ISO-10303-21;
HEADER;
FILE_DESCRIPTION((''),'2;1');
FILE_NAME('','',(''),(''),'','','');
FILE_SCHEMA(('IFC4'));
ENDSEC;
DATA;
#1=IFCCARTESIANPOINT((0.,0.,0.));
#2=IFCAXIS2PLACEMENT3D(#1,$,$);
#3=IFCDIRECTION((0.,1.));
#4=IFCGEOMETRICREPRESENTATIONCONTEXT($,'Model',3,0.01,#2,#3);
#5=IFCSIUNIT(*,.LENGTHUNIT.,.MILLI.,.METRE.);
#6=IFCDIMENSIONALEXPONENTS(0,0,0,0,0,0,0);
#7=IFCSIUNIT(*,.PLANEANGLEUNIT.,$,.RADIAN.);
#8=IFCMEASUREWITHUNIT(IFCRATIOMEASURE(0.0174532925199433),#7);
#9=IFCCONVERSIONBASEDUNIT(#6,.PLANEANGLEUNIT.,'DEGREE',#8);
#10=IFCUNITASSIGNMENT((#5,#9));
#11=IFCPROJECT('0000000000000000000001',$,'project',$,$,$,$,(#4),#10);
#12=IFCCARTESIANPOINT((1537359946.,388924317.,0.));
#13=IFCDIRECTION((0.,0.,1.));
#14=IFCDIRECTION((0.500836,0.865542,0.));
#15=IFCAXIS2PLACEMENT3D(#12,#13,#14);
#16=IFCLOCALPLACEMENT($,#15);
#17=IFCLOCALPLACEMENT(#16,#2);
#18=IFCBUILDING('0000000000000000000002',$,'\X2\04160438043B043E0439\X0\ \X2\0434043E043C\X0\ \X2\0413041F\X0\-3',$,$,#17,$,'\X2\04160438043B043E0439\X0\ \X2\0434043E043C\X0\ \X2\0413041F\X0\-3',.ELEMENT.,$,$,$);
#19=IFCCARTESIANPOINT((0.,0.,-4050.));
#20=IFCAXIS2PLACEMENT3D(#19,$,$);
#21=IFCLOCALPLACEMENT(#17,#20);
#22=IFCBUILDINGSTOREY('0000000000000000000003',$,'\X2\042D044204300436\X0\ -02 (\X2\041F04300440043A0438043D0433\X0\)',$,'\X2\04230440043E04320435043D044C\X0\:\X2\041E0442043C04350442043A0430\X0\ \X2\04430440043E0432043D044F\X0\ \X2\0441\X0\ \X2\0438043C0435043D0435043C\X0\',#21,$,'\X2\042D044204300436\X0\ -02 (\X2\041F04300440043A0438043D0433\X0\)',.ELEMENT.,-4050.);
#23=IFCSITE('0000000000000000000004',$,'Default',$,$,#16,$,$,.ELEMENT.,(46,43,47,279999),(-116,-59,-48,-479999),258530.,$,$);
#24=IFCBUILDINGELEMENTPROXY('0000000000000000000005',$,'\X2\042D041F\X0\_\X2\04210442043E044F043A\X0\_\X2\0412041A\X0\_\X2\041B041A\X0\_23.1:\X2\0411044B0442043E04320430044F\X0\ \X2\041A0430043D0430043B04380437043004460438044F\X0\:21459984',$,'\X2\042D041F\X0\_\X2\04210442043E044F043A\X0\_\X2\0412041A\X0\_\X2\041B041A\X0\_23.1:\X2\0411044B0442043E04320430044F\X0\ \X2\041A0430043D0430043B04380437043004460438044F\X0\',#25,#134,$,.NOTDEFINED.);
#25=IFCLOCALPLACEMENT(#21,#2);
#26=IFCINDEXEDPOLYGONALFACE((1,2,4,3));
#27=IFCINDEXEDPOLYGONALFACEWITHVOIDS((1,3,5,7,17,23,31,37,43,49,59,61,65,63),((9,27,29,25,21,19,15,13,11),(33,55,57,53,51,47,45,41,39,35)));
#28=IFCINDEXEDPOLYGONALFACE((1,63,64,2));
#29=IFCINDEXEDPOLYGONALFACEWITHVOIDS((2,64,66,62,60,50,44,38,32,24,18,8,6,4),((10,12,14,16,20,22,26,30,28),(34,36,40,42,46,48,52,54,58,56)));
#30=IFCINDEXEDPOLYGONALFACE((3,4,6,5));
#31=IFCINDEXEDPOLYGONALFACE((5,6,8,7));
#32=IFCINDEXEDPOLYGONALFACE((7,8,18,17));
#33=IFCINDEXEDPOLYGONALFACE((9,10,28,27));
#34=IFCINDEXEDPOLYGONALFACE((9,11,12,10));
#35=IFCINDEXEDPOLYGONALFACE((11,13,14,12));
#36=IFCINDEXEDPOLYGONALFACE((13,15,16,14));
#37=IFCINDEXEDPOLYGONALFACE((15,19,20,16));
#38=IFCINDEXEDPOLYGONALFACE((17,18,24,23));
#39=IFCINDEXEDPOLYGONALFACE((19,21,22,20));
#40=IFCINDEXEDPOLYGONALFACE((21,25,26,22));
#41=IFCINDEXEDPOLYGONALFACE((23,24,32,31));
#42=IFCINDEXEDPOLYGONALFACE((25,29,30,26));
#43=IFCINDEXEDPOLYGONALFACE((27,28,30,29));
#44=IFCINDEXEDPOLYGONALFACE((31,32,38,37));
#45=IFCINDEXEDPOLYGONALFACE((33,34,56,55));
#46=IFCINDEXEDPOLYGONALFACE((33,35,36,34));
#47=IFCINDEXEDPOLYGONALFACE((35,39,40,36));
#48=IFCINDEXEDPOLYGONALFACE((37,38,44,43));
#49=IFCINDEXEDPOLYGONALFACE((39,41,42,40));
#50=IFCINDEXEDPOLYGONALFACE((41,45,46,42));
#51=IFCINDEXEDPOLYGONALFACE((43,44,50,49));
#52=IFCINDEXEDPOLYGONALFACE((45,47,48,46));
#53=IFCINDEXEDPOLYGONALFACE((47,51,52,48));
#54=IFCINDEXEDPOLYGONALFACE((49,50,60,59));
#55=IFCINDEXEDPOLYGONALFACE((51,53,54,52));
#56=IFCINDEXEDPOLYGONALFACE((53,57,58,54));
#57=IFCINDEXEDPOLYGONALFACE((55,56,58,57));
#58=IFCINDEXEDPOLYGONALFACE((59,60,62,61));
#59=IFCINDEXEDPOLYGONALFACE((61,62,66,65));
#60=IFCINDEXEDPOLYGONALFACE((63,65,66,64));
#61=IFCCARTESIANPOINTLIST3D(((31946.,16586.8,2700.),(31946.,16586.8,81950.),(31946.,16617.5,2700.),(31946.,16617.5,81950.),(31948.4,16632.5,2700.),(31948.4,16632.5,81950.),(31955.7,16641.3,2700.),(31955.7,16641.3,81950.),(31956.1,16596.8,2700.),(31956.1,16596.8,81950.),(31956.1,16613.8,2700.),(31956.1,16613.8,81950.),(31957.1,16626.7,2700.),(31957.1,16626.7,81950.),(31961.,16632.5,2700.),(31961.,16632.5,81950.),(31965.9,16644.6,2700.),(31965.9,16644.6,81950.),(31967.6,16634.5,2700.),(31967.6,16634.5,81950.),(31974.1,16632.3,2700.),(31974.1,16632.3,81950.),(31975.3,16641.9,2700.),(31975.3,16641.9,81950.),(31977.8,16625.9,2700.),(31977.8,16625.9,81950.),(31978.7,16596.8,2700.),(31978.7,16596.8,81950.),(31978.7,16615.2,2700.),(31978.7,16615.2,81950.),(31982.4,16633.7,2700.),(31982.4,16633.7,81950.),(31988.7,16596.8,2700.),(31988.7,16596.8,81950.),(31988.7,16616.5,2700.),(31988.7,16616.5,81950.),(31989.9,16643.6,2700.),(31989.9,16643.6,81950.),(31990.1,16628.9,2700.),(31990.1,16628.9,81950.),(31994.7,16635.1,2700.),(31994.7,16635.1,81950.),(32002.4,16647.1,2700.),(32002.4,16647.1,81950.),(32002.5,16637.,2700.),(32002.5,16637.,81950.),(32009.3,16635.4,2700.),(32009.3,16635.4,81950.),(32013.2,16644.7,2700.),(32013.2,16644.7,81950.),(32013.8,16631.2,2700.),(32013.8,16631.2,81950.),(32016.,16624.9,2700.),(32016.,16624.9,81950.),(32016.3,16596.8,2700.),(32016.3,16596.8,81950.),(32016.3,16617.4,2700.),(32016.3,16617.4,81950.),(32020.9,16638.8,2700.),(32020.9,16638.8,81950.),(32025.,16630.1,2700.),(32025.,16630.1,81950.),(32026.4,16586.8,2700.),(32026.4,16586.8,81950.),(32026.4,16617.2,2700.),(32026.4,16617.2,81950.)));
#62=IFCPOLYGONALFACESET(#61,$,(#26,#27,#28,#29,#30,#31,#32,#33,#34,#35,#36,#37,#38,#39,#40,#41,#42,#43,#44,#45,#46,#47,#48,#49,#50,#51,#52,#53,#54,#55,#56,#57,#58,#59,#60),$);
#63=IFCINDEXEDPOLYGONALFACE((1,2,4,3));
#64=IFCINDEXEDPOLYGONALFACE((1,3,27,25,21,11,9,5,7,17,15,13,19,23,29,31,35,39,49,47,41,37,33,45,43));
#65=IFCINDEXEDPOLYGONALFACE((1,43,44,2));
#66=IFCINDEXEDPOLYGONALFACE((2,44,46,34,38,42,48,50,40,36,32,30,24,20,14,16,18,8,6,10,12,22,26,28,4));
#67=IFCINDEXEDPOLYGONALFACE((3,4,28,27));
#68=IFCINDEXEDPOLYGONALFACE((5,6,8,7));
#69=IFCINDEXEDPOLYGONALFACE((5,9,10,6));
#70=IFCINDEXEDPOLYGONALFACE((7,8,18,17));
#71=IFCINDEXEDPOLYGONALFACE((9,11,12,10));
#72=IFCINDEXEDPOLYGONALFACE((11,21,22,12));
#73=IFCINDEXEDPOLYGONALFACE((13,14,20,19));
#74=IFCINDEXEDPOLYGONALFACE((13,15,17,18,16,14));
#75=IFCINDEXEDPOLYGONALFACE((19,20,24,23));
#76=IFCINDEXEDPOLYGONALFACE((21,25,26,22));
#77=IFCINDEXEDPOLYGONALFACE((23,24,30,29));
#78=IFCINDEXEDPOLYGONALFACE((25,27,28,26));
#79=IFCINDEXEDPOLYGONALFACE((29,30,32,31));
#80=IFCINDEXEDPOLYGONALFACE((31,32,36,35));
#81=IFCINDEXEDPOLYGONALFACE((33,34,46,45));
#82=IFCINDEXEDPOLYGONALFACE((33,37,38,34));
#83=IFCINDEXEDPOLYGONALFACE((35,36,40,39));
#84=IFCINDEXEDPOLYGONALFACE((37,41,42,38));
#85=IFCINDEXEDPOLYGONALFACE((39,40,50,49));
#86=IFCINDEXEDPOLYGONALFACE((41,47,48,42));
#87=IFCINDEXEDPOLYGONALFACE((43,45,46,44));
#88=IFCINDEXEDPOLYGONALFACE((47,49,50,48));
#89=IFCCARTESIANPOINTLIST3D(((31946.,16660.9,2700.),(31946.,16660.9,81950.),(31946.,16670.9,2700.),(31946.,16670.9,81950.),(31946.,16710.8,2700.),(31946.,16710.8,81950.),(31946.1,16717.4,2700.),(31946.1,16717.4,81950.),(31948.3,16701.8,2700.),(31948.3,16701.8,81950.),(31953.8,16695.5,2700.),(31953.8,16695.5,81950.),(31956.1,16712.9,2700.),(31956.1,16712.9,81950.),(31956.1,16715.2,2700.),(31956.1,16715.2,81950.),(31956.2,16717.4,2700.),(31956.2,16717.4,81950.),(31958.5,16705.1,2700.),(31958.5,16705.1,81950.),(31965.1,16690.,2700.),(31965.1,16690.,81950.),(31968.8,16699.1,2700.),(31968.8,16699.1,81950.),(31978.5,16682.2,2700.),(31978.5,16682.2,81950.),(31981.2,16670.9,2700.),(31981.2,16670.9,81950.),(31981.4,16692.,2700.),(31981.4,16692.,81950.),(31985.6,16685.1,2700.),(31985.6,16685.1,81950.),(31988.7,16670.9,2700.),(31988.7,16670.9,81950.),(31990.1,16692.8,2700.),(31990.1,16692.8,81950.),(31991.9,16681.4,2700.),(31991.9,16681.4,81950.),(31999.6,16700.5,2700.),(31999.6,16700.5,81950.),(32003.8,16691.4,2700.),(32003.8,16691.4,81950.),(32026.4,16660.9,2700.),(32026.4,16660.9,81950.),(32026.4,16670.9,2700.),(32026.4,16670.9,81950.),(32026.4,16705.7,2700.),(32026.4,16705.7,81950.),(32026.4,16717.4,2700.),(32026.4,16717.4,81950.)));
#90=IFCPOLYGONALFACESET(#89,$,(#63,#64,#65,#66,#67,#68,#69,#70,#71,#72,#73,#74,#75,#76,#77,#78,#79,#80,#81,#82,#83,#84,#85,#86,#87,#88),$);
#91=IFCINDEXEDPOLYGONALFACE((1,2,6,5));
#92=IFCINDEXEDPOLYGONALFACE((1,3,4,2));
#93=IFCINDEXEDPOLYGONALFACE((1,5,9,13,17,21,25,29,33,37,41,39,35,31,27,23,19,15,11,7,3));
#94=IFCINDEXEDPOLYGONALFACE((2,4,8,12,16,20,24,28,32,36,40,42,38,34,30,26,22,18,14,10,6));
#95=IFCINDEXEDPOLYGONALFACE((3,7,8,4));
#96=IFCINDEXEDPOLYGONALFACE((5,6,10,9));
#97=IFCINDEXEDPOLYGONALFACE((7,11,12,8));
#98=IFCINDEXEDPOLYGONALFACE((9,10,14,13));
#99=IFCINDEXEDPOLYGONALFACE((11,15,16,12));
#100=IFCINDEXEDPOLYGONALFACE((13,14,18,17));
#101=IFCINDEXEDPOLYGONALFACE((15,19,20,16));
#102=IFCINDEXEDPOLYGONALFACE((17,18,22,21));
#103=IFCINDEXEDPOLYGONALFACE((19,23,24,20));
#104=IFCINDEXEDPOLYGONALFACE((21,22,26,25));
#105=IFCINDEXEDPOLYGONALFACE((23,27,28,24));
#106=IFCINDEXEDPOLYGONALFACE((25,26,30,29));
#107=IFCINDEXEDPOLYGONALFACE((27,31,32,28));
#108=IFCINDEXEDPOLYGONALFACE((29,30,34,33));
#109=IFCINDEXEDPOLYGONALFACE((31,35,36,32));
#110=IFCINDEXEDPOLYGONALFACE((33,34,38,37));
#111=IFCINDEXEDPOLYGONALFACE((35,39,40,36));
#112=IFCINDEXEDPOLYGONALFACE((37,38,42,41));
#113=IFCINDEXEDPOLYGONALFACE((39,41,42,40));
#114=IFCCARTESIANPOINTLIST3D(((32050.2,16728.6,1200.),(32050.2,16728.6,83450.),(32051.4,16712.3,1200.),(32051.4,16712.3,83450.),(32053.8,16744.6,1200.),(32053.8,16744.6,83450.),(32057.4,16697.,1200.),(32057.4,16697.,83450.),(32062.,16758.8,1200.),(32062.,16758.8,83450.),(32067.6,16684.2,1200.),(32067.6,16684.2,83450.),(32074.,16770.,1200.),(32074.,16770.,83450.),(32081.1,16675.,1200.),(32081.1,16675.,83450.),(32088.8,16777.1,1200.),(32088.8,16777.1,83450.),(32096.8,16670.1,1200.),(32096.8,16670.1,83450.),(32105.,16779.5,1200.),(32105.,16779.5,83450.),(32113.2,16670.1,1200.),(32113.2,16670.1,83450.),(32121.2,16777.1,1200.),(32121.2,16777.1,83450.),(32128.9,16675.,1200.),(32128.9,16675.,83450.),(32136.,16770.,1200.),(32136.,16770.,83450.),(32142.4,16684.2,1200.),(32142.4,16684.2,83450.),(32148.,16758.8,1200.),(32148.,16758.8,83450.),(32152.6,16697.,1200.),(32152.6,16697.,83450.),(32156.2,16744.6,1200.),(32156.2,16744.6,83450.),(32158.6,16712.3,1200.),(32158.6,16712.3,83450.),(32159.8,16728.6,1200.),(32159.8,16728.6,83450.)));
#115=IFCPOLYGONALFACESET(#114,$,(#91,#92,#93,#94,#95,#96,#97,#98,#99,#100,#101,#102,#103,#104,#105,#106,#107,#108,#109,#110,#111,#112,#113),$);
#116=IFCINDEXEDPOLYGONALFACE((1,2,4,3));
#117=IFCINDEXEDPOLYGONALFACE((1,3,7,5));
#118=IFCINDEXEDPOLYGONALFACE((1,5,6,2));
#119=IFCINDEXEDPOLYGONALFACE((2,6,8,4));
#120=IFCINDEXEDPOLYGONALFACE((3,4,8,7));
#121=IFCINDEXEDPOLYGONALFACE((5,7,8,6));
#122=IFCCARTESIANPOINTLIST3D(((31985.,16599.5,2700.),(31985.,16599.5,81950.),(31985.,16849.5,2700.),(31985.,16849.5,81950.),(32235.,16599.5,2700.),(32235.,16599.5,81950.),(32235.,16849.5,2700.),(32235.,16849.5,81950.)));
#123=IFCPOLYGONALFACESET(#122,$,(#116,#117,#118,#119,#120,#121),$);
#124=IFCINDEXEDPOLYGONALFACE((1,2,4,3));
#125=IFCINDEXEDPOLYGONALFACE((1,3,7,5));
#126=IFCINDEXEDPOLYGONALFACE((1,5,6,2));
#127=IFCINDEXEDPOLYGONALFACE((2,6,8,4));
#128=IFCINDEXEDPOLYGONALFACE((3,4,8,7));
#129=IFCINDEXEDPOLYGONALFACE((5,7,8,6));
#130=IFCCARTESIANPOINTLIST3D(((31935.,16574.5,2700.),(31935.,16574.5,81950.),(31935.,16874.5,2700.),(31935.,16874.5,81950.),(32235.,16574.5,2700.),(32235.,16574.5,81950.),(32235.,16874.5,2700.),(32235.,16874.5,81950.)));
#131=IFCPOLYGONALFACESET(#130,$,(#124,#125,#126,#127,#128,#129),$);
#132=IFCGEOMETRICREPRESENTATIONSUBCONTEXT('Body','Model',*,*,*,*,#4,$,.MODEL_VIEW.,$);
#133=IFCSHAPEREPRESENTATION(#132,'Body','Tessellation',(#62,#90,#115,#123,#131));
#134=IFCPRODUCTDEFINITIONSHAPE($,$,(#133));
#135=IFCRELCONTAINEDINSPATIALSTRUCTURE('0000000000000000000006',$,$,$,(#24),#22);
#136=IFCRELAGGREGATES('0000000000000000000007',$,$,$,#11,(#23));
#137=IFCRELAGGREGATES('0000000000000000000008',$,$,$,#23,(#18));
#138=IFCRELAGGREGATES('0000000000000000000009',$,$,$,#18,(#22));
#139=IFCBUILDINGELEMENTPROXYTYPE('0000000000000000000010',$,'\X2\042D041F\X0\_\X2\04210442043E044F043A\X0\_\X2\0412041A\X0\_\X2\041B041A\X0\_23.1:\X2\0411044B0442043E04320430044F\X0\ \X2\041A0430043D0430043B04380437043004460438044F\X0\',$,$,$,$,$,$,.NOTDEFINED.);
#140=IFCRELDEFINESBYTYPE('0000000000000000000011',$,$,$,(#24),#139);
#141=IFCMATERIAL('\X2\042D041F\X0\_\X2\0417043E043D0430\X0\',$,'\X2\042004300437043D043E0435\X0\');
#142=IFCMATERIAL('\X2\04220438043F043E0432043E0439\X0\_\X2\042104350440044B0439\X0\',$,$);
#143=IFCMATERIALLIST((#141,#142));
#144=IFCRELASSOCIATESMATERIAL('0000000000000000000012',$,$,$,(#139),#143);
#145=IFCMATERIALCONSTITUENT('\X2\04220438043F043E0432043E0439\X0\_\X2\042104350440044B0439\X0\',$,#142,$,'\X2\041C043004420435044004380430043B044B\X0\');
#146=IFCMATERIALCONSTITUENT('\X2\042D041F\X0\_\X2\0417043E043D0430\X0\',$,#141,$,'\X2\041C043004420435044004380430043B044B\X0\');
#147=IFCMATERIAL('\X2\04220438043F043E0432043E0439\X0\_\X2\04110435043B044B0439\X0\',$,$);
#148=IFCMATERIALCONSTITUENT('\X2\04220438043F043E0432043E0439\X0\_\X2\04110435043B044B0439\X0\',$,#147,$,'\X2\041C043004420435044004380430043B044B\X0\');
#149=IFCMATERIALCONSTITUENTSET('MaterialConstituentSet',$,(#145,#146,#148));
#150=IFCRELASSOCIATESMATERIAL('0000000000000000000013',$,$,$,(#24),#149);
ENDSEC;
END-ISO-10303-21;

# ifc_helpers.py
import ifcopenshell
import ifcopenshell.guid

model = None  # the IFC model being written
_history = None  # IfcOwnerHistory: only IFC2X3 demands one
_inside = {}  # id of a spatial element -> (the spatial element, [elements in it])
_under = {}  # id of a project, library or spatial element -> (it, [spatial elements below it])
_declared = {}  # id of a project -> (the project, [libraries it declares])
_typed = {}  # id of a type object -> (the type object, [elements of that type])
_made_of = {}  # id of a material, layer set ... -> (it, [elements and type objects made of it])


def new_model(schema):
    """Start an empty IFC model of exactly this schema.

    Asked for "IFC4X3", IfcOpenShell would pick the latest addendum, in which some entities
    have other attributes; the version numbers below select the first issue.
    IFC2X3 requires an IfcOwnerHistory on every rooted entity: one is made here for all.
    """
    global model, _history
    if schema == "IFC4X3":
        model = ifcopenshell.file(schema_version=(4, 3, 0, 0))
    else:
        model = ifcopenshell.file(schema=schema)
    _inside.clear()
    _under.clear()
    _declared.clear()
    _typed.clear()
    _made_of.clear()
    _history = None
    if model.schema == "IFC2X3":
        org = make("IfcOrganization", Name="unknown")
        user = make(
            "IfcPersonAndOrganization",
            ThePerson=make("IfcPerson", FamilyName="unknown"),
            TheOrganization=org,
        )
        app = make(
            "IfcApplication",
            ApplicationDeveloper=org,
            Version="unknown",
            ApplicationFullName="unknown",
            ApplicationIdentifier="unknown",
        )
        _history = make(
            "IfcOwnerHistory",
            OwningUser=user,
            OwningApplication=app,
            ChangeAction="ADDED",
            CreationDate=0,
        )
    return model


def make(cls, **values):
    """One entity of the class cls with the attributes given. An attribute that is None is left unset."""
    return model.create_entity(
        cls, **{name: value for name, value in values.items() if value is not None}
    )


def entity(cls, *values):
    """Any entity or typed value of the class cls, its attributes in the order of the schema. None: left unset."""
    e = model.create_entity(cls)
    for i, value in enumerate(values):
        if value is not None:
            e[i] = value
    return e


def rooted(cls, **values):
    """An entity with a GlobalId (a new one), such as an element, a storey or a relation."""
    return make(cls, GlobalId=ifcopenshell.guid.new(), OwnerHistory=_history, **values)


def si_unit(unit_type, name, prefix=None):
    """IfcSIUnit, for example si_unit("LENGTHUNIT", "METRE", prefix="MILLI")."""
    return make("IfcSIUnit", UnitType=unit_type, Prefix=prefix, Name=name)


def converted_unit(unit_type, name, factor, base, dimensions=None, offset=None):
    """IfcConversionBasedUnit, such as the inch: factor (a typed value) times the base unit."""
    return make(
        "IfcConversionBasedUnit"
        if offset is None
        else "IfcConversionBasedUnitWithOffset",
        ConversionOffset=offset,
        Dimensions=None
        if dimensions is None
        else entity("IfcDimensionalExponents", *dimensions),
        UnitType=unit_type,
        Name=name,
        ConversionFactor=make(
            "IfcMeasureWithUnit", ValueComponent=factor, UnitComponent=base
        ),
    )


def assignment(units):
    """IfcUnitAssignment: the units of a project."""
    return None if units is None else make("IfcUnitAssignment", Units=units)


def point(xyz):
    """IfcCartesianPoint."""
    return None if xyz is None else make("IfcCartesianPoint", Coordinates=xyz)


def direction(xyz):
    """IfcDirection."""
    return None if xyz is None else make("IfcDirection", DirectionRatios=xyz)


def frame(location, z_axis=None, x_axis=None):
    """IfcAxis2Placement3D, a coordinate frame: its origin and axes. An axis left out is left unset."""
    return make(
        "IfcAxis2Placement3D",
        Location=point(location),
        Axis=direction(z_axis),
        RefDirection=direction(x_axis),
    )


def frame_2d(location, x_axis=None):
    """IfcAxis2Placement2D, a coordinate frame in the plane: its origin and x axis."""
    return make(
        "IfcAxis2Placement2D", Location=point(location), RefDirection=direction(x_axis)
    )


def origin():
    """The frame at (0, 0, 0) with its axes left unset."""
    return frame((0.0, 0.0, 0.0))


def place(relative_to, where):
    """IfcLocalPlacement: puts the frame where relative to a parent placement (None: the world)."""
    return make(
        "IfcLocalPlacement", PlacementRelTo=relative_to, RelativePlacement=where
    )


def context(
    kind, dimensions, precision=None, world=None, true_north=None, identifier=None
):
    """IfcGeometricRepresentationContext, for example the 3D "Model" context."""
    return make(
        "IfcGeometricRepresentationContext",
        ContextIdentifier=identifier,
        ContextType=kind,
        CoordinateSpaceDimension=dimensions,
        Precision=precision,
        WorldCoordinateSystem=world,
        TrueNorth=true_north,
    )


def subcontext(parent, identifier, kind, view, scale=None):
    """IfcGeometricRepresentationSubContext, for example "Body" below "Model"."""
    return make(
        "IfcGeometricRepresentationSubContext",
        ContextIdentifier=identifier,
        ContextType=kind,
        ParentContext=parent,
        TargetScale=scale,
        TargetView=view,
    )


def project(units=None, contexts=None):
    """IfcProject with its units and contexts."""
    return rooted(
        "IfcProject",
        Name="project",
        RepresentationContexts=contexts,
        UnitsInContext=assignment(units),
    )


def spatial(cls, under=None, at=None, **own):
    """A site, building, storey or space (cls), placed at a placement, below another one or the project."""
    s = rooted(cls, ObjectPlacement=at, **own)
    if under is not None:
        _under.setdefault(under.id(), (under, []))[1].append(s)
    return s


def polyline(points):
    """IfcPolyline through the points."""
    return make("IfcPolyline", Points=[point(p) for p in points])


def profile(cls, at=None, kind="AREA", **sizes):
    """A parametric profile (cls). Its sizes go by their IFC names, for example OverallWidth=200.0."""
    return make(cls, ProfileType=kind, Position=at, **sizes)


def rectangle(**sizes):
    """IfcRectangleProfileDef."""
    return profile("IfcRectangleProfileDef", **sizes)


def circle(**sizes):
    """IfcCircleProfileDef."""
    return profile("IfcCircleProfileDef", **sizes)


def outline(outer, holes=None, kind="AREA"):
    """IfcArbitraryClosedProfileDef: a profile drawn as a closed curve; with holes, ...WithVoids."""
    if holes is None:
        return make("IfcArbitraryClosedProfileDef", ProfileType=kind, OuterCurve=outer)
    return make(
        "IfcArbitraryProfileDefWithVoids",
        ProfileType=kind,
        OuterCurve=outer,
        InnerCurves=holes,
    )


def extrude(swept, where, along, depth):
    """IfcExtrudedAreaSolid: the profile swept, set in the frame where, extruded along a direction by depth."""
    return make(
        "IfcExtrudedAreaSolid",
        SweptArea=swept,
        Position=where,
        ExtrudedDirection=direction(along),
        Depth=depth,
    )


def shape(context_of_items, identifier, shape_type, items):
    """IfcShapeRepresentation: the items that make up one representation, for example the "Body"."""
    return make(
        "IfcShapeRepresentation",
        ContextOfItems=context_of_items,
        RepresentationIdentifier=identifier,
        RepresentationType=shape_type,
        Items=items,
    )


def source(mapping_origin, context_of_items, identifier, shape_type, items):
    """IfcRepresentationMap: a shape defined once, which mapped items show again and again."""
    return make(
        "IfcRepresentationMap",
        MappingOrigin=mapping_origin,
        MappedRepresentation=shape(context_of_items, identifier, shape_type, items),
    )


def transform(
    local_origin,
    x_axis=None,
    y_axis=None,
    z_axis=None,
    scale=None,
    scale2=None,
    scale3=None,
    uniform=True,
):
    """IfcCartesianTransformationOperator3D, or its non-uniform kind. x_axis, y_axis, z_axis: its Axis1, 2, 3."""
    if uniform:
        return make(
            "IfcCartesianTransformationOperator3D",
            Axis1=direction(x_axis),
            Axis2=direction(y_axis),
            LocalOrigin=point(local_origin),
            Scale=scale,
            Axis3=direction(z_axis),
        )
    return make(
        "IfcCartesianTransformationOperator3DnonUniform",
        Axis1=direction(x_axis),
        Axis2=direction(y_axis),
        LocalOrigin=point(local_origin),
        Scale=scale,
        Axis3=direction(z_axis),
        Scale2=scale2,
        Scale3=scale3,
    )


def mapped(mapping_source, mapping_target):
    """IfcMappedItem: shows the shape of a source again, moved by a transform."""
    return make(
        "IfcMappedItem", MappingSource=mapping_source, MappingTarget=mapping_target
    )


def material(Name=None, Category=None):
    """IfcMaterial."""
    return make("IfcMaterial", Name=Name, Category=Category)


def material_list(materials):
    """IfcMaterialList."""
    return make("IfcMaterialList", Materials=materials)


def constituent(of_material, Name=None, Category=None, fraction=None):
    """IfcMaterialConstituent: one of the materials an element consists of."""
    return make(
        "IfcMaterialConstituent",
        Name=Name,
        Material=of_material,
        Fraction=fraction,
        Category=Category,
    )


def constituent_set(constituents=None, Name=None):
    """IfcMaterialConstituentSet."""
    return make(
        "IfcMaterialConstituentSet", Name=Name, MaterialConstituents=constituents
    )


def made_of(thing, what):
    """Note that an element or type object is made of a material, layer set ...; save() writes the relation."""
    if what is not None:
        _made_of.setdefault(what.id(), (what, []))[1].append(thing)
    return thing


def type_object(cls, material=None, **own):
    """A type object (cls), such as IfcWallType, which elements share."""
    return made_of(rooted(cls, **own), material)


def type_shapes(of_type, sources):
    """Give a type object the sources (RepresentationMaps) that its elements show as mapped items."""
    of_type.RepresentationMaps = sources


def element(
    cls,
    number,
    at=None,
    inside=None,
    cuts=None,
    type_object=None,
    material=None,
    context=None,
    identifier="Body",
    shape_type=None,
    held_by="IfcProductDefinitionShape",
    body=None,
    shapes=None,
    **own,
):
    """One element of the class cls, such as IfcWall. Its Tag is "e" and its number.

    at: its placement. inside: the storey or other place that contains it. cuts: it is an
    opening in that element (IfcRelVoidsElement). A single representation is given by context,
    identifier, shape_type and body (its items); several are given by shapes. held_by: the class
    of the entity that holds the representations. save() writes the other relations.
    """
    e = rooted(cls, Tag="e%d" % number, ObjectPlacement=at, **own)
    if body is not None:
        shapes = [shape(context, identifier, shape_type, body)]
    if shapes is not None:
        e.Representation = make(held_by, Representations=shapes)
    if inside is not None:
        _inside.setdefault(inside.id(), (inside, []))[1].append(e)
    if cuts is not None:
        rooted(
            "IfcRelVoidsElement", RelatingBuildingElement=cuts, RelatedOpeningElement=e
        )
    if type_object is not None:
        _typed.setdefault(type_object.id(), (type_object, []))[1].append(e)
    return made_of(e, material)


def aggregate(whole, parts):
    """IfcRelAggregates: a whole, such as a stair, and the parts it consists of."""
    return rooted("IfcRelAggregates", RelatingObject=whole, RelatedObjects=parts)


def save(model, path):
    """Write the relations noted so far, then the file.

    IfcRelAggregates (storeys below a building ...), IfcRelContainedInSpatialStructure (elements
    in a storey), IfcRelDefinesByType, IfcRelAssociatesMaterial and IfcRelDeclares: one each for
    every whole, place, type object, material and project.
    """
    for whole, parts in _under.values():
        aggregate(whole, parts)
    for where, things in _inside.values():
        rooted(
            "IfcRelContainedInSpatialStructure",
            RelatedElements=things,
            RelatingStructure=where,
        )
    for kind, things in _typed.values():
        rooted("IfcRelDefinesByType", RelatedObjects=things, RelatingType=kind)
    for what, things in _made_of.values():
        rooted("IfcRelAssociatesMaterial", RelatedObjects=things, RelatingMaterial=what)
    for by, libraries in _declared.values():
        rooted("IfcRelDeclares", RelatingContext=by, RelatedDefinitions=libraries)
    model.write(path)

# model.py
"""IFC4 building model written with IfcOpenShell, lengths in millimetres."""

from ifc_helpers import new_model, entity, si_unit, converted_unit, direction, frame, frame_2d, origin, place, context, subcontext, project, spatial, polyline, rectangle, circle, outline, extrude, source, transform, mapped, material, material_list, constituent, constituent_set, type_object, type_shapes, element, save


model = new_model("IFC4")

# Units and contexts
model_context = context("Model", 3, precision=0.01, world=origin(), true_north=direction((0.0, 1.0)))
body_context = subcontext(model_context, "Body", "Model", "MODEL_VIEW")
ifc_project = project(units=[si_unit("LENGTHUNIT", "METRE", prefix="MILLI"), converted_unit("PLANEANGLEUNIT", "DEGREE", entity("IfcRatioMeasure", 0.0174532925199433), si_unit("PLANEANGLEUNIT", "RADIAN"), dimensions=[0, 0, 0, 0, 0, 0, 0])], contexts=[model_context])

# Site, building, storey
site_placement = place(None, frame((1537359946.0, 388924317.0, 0.0), z_axis=(0.0, 0.0, 1.0), x_axis=(0.500836, 0.865542, 0.0)))
site = spatial("IfcSite", under=ifc_project, at=site_placement, Name="Default", CompositionType="ELEMENT", RefLatitude=(46, 43, 47, 279999), RefLongitude=(-116, -59, -48, -479999), RefElevation=258530.0)
building_placement = place(site_placement, origin())
building = spatial("IfcBuilding", under=site, at=building_placement, Name="Жилой дом ГП-3", LongName="Жилой дом ГП-3", CompositionType="ELEMENT")
storey_placement = place(building_placement, frame((0.0, 0.0, -4050.0)))
storey = spatial("IfcBuildingStorey", under=building, at=storey_placement, Name="Этаж -02 (Паркинг)", ObjectType="Уровень:Отметка уровня с именем", LongName="Этаж -02 (Паркинг)", CompositionType="ELEMENT", Elevation=-4050.0)

# Building element proxy
ifc_material_1 = material(Name="ЭП_Зона", Category="Разное")
ifc_material_2 = material(Name="Типовой_Белый")
ifc_material_3 = material(Name="Типовой_Серый")
ifc_material_list_1 = material_list([ifc_material_1, ifc_material_3])
building_element_proxy_type_1 = type_object("IfcBuildingElementProxyType", Name="ЭП_Стояк_ВК_ЛК_23.1:Бытовая Канализация", PredefinedType="NOTDEFINED", material=ifc_material_list_1)
shared_shape_1 = source(origin(), body_context, "Body", "SweptSolid", [
    extrude(outline(polyline([(-42.2, -39.0), (-11.8, -39.0), (1.1, -37.6), (9.8, -33.5), (15.7, -25.8), (18.0, -15.0), (14.6, -2.5), (4.7, 5.0), (12.8, 12.1), (15.5, 21.5), (12.3, 31.8), (3.4, 39.0), (-11.6, 41.4), (-42.2, 41.4), (-42.2, -39.0)]), holes=[polyline([(-32.2, 8.8), (-32.2, 31.4), (-15.2, 31.4), (-2.3, 30.3), (3.5, 26.4), (5.5, 19.9), (3.3, 13.3), (-3.1, 9.6), (-13.9, 8.8), (-32.2, 8.8)]), polyline([(-32.2, -28.9), (-32.2, -1.3), (-12.6, -1.3), (-0.2, -2.6), (6.1, -7.3), (8.0, -15.1), (6.3, -21.9), (2.2, -26.3), (-4.1, -28.5), (-11.6, -28.9), (-32.2, -28.9)])]), frame((54.5, -52.4, -1350.0)), (0.0, 0.0, 1.0), 79250.0),
    extrude(outline(polyline([(-32.1, -31.9), (48.3, -31.9), (48.3, -21.8), (10.6, -21.8), (13.8, -11.4), (25.6, -1.3), (48.3, 13.0), (48.3, 24.6), (21.4, 7.7), (12.0, 0.1), (7.4, -7.7), (3.3, -0.7), (-9.3, 6.4), (-19.7, 12.3), (-22.1, 20.2), (-22.0, 22.4), (-22.0, 24.6), (-32.0, 24.6), (-32.1, 18.0), (-29.9, 9.0), (-24.3, 2.8), (-13.1, -2.8), (0.4, -10.6), (3.0, -21.8), (-32.1, -21.8), (-32.1, -31.9)])), frame((118.2, -43.1, -1350.0), z_axis=(0.0, 0.0, 1.0), x_axis=(0.0, -1.0, 0.0)), (0.0, 0.0, 1.0), 79250.0),
    extrude(circle(Radius=55.0, at=frame_2d((0.0, 0.0), x_axis=(1.0, 0.0))), frame((150.0, -170.0, -2850.0)), (0.0, 0.0, 1.0), 82250.0),
    extrude(rectangle(XDim=250.0, YDim=250.0, at=frame_2d((0.0, 0.0), x_axis=(1.0, 0.0))), frame((150.0, -175.0, -1350.0)), (0.0, 0.0, 1.0), 79250.0),
    extrude(rectangle(XDim=300.0, YDim=300.0, at=frame_2d((0.0, 0.0), x_axis=(1.0, 0.0))), frame((150.0, -150.0, -1350.0)), (0.0, 0.0, 1.0), 79250.0),
])
type_shapes(building_element_proxy_type_1, [shared_shape_1])
ifc_constituent_1 = constituent(ifc_material_3, Name="Типовой_Серый", Category="Материалы")
ifc_constituent_2 = constituent(ifc_material_1, Name="ЭП_Зона", Category="Материалы")
ifc_constituent_3 = constituent(ifc_material_2, Name="Типовой_Белый", Category="Материалы")
ifc_constituent_set_1 = constituent_set(constituents=[ifc_constituent_1, ifc_constituent_2, ifc_constituent_3], Name="MaterialConstituentSet")
proxy_1_placement = place(storey_placement, frame((31935.0, 16574.5, 4050.0), z_axis=(0.0, 0.0, 1.0), x_axis=(0.0, 1.0, 0.0)))
element("IfcBuildingElementProxy", 1, at=proxy_1_placement, inside=storey, type_object=building_element_proxy_type_1, material=ifc_constituent_set_1, Name="ЭП_Стояк_ВК_ЛК_23.1:Бытовая Канализация:21459984", ObjectType="ЭП_Стояк_ВК_ЛК_23.1:Бытовая Канализация", PredefinedType="NOTDEFINED", context=body_context, shape_type="MappedRepresentation", body=[
    mapped(shared_shape_1, transform((0.0, 0.0, 0.0), scale=1.0)),
])

save(model, "model.ifc")
